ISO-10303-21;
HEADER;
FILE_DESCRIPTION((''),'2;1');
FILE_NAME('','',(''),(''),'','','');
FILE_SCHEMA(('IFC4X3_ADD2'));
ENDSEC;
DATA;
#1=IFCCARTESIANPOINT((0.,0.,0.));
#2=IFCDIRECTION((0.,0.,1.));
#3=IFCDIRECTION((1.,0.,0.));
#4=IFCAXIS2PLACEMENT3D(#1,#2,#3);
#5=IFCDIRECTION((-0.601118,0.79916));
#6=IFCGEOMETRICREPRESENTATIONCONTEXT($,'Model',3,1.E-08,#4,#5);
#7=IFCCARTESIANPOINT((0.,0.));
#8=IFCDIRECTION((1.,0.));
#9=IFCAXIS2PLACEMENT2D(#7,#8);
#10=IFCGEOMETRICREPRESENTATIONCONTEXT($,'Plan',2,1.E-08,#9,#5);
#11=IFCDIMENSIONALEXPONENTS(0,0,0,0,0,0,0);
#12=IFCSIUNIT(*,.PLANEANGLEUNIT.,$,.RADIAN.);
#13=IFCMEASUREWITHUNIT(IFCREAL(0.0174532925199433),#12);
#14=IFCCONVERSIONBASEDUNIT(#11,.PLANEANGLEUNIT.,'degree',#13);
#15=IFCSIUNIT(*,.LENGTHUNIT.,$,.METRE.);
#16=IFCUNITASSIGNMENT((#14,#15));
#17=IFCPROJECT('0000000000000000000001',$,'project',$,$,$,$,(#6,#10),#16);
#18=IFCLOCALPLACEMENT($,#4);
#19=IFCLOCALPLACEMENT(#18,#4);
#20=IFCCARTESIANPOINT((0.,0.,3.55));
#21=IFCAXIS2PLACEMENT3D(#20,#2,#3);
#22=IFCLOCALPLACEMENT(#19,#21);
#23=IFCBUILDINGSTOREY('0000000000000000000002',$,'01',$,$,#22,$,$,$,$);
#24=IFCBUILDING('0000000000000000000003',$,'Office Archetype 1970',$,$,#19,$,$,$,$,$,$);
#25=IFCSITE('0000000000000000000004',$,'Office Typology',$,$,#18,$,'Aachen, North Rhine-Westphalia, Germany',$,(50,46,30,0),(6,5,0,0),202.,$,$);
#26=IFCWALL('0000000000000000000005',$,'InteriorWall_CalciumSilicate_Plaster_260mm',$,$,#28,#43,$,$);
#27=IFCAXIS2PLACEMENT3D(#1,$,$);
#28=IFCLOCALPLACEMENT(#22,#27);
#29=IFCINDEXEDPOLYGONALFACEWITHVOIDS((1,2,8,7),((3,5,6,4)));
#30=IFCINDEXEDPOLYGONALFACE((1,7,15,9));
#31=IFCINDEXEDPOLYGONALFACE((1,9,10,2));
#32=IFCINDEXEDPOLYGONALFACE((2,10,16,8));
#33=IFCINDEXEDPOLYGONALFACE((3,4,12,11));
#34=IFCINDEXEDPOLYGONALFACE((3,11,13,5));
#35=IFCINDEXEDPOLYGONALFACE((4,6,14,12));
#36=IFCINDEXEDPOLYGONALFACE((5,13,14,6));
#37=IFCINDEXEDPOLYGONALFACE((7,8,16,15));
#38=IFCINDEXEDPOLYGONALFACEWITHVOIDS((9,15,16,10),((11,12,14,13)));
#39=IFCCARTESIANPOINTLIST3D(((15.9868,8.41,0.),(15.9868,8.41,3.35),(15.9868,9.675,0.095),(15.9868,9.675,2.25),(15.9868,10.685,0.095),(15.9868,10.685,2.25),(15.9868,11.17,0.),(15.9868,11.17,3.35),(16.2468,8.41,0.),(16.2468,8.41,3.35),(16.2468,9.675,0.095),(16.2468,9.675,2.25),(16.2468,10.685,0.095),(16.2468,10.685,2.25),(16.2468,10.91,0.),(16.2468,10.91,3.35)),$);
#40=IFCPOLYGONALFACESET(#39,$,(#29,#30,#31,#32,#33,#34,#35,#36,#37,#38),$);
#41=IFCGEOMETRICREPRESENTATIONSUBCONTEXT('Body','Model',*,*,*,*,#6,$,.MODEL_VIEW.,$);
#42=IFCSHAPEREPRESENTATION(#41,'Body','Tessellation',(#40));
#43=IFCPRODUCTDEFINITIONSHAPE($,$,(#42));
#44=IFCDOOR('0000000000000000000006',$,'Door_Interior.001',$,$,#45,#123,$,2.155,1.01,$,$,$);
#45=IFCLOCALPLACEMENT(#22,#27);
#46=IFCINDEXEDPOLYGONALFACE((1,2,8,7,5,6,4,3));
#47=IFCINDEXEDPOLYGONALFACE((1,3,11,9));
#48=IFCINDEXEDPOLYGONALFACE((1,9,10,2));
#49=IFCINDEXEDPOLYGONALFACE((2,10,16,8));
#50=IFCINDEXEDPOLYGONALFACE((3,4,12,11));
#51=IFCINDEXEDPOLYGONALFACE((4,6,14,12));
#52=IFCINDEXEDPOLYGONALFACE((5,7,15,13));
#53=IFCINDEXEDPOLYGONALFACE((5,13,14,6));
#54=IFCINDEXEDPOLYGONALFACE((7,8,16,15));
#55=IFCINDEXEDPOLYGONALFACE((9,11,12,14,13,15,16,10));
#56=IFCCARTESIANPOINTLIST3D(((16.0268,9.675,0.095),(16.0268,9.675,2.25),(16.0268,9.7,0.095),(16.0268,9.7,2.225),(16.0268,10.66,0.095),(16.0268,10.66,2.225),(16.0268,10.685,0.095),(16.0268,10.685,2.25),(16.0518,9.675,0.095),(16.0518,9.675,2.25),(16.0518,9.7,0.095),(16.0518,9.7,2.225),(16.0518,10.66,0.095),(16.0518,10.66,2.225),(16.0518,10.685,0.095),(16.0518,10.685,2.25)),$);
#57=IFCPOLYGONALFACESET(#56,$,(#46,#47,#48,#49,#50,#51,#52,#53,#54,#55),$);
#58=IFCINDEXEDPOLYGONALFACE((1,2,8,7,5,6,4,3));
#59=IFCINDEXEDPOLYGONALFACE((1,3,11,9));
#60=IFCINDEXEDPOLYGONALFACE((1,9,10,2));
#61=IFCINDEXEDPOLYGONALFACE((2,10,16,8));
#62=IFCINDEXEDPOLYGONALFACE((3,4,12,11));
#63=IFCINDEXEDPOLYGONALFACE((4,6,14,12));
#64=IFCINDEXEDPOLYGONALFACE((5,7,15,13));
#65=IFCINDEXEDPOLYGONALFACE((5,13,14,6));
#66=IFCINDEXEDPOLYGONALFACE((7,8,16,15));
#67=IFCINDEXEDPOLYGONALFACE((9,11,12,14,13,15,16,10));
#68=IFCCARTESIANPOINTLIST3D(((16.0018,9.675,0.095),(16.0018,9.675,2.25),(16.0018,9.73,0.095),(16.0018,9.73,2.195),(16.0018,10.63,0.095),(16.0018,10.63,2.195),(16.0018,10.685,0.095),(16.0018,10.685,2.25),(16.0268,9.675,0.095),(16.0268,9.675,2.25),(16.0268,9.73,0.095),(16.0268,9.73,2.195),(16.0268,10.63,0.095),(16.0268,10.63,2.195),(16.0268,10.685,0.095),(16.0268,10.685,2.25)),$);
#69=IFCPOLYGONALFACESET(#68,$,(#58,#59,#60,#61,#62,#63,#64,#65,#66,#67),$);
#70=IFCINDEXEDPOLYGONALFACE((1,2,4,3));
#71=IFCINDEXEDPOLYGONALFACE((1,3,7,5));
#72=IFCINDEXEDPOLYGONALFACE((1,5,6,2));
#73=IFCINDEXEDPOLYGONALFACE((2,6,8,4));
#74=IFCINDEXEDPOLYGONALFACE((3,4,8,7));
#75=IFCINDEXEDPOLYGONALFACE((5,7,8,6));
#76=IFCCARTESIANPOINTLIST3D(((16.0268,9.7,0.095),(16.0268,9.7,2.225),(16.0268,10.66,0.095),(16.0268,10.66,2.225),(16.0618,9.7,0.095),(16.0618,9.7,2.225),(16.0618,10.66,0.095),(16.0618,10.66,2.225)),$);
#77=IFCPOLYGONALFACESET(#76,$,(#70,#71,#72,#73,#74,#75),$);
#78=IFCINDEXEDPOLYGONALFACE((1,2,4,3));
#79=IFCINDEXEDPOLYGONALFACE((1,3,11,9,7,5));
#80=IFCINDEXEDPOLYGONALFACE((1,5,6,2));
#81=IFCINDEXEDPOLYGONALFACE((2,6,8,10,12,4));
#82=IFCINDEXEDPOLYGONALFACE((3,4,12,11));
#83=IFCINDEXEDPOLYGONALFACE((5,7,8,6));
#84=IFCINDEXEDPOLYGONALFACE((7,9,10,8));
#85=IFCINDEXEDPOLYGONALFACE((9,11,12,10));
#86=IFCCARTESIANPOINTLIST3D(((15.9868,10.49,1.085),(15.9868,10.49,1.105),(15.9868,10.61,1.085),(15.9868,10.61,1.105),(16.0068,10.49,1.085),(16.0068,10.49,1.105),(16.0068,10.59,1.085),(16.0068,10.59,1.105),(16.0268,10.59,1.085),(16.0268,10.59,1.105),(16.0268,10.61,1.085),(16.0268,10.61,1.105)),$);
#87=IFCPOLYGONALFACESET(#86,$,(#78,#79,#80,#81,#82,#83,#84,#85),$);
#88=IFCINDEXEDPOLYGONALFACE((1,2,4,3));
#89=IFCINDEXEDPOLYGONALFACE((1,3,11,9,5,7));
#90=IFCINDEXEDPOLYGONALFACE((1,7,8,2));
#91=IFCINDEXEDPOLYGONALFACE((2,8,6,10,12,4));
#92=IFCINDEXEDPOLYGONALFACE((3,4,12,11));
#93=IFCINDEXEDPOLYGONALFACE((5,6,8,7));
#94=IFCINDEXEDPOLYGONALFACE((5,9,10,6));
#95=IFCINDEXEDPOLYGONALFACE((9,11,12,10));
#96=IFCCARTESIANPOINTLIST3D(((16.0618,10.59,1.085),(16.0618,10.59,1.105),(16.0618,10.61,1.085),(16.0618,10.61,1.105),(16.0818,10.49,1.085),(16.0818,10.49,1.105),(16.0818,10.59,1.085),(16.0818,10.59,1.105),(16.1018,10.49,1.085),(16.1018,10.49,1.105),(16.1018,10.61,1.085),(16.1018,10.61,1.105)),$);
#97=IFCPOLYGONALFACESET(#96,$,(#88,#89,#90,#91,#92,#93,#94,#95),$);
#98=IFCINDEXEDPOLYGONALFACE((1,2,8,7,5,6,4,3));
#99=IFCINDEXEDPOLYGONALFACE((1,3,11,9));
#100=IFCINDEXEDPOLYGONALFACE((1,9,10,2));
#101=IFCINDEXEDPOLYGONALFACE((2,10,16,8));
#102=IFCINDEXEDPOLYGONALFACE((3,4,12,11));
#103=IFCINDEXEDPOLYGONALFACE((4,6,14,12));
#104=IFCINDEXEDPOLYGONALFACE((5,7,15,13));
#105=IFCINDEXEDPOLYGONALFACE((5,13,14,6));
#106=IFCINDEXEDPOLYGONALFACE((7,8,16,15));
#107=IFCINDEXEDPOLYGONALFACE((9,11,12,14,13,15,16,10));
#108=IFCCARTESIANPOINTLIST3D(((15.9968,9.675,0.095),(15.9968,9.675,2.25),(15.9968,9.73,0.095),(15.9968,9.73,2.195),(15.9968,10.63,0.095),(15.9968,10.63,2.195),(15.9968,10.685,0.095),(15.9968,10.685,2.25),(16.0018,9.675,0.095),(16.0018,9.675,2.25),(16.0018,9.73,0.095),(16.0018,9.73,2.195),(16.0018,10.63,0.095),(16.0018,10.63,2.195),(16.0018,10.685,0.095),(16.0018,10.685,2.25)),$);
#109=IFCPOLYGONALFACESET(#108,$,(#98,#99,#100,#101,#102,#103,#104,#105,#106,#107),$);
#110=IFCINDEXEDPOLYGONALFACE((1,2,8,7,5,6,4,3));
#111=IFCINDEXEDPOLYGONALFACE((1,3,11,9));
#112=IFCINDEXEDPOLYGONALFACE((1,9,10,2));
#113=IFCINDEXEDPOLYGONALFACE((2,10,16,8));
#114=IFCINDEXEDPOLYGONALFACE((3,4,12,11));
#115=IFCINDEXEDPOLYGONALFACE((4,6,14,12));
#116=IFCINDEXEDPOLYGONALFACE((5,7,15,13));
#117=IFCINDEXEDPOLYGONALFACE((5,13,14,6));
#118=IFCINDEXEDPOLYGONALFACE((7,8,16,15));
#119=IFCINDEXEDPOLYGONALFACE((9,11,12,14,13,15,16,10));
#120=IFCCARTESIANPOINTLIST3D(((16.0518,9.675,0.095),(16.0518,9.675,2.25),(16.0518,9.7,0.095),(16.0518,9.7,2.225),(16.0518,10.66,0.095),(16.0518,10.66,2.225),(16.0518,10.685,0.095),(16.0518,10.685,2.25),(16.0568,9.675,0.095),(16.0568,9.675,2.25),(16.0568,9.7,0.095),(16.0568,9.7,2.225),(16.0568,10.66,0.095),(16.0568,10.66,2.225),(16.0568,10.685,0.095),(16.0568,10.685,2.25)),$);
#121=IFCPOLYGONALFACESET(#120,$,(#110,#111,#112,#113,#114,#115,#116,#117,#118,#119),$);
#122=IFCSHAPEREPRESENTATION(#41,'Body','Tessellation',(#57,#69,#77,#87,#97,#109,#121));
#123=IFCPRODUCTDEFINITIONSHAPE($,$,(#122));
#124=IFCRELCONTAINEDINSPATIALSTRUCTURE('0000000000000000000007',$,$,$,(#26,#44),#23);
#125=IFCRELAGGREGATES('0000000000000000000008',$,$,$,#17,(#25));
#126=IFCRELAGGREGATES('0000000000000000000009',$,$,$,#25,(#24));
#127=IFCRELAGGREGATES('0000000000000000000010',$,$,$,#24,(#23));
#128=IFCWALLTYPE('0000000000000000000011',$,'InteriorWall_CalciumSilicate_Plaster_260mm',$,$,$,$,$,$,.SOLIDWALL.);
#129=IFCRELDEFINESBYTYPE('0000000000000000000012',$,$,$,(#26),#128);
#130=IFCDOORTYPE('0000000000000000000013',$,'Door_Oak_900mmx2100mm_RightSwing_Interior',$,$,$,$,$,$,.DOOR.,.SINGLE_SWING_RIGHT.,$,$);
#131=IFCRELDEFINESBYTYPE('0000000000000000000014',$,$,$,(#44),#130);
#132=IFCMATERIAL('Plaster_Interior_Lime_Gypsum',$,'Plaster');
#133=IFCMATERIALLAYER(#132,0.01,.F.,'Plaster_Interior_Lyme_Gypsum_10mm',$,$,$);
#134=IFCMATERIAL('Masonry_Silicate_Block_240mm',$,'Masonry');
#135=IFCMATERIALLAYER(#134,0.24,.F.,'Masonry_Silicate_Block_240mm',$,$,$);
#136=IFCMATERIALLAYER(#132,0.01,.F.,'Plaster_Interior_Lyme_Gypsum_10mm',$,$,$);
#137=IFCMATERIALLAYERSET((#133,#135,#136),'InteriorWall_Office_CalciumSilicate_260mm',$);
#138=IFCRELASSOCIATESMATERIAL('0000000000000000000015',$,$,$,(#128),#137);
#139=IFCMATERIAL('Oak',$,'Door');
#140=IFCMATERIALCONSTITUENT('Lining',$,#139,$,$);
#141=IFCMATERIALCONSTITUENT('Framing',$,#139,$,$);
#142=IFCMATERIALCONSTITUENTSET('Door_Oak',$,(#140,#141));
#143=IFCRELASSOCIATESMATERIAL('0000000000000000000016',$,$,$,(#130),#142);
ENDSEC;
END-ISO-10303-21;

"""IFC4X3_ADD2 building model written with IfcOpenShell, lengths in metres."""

from ifc_helpers import new_model, entity, si_unit, converted_unit, direction, frame, origin_with_axes, origin_2d_with_axis, place, context, subcontext, project, spatial, line, indexed_curve, outline, extrude, source, transform, mapped, material, layer, layer_set, constituent, constituent_set, type_object, type_shapes, element, fill, save


model = new_model("IFC4X3_ADD2")

# Units and contexts
model_context = context("Model", 3, precision=1e-08, world=origin_with_axes(), true_north=direction((-0.601118, 0.79916)))
plan_context = context("Plan", 2, precision=1e-08, world=origin_2d_with_axis(), true_north=direction((-0.601118, 0.79916)))
body_context = subcontext(model_context, "Body", "Model", "MODEL_VIEW")
ifc_project = project(units=[converted_unit("PLANEANGLEUNIT", "degree", entity("IfcReal", 0.0174532925199433), si_unit("PLANEANGLEUNIT", "RADIAN"), dimensions=[0, 0, 0, 0, 0, 0, 0]), si_unit("LENGTHUNIT", "METRE")], contexts=[model_context, plan_context])

# Site, building, storey
site_placement = place(None, origin_with_axes())
site = spatial("IfcSite", under=ifc_project, at=site_placement, Name="Office Typology", LongName="Aachen, North Rhine-Westphalia, Germany", RefLatitude=(50, 46, 30, 0), RefLongitude=(6, 5, 0, 0), RefElevation=202.0)
building_placement = place(site_placement, origin_with_axes())
building = spatial("IfcBuilding", under=site, at=building_placement, Name="Office Archetype 1970")
storey_placement = place(building_placement, frame((0.0, 0.0, 3.55), z_axis=(0.0, 0.0, 1.0), x_axis=(1.0, 0.0, 0.0)))
storey = spatial("IfcBuildingStorey", under=building, at=storey_placement, Name="01")

# Wall, opening, door
ifc_material_1 = material(Name="Plaster_Interior_Lime_Gypsum", Category="Plaster")
ifc_layer_1 = layer(ifc_material_1, 0.01, ventilated=False, Name="Plaster_Interior_Lyme_Gypsum_10mm")
ifc_material_2 = material(Name="Masonry_Silicate_Block_240mm", Category="Masonry")
ifc_layer_2 = layer(ifc_material_2, 0.24, ventilated=False, Name="Masonry_Silicate_Block_240mm")
ifc_layer_3 = layer(ifc_material_1, 0.01, ventilated=False, Name="Plaster_Interior_Lyme_Gypsum_10mm")
ifc_layer_set_1 = layer_set([ifc_layer_1, ifc_layer_2, ifc_layer_3], Name="InteriorWall_Office_CalciumSilicate_260mm")
wall_type_1 = type_object("IfcWallType", Name="InteriorWall_CalciumSilicate_Plaster_260mm", PredefinedType="SOLIDWALL", material=ifc_layer_set_1)
wall_1_placement = place(storey_placement, frame((15.9868, 11.17, 0.0), z_axis=(0.0, 0.0, 1.0), x_axis=(0.0, -1.0, 0.0)))
wall_1 = element("IfcWall", 1, at=wall_1_placement, inside=storey, type_object=wall_type_1, Name="InteriorWall_CalciumSilicate_Plaster_260mm", context=body_context, shape_type="SweptSolid", body=[
    extrude(outline(indexed_curve([(0.0, 0.0), (0.26, 0.26), (2.76, 0.26), (2.76, 0.0)], segments=[line(1, 2, 3, 4, 1)])), origin_with_axes(), (0.0, 0.0, 1.0), 3.35),
])
shared_shape_1 = source(origin_with_axes(), body_context, "Body", "SweptSolid", [
    extrude(outline(indexed_curve([(0.0, 0.0), (1.01, 0.0), (1.01, 2.155), (0.0, 2.155), (0.0, 0.0)])), frame((0.0, -0.015, 0.0), z_axis=(0.0, -1.0, 0.0), x_axis=(1.0, 0.0, 0.0)), (0.0, 0.0, -1.0), 0.26),
])
opening_1_placement = place(wall_1_placement, frame((0.485, 0.015, 0.095), z_axis=(0.0, 0.0, 1.0), x_axis=(1.0, 0.0, 0.0)))
opening_1 = element("IfcOpeningElement", 2, at=opening_1_placement, cuts=wall_1, PredefinedType="OPENING", context=body_context, shape_type="MappedRepresentation", body=[
    mapped(shared_shape_1, transform((0.0, 0.0, 0.0), x_axis=(1.0, 0.0, 0.0), y_axis=(0.0, 1.0, 0.0), z_axis=(0.0, 0.0, 1.0), scale=1.0)),
])
ifc_material_3 = material(Name="Oak", Category="Door")
ifc_constituent_1 = constituent(ifc_material_3, Name="Lining")
ifc_constituent_2 = constituent(ifc_material_3, Name="Framing")
ifc_constituent_set_1 = constituent_set(constituents=[ifc_constituent_1, ifc_constituent_2], Name="Door_Oak")
door_type = type_object("IfcDoorType", Name="Door_Oak_900mmx2100mm_RightSwing_Interior", OperationType="SINGLE_SWING_RIGHT", PredefinedType="DOOR", material=ifc_constituent_set_1)
shared_shape_2 = source(origin_with_axes(), body_context, "Body", "SweptSolid", [
    extrude(outline(indexed_curve([(0.0, 0.0), (0.0, 2.155), (1.01, 2.155), (1.01, 0.0), (0.985, 0.0), (0.985, 2.13), (0.025, 2.13), (0.025, 0.0)], segments=[line(1, 2, 3, 4, 5, 6, 7, 8, 1)])), frame((0.0, 0.025, 0.0), z_axis=(0.0, -1.0, 0.0), x_axis=(1.0, 0.0, 0.0)), (0.0, 0.0, -1.0), 0.025),
    extrude(outline(indexed_curve([(0.0, 0.0), (0.0, 2.155), (1.01, 2.155), (1.01, 0.0), (0.955, 0.0), (0.955, 2.1), (0.055, 2.1), (0.055, 0.0)], segments=[line(1, 2, 3, 4, 5, 6, 7, 8, 1)])), frame((0.0, 0.0, 0.0), z_axis=(0.0, -1.0, 0.0), x_axis=(1.0, 0.0, 0.0)), (0.0, 0.0, -1.0), 0.025),
    extrude(outline(indexed_curve([(0.0, 0.0), (0.96, 0.0), (0.96, 0.035), (0.0, 0.035)], segments=[line(1, 2, 3, 4, 1)])), frame((0.025, 0.025, 0.0), z_axis=(0.0, 0.0, 1.0), x_axis=(1.0, 0.0, 0.0)), (0.0, 0.0, 1.0), 2.13),
    extrude(outline(indexed_curve([(0.0, 0.0), (0.0, -0.04), (0.12, -0.04), (0.12, -0.02), (0.02, -0.02), (0.02, 0.0)], segments=[line(1, 2, 3, 4, 5, 6, 1)])), frame((0.075, 0.025, 0.99), z_axis=(0.0, 0.0, 1.0), x_axis=(1.0, 0.0, 0.0)), (0.0, 0.0, 1.0), 0.02),
    extrude(outline(indexed_curve([(0.0, 0.0), (0.0, 0.04), (0.12, 0.04), (0.12, 0.02), (0.02, 0.02), (0.02, 0.0)], segments=[line(1, 2, 3, 4, 5, 6, 1)])), frame((0.075, 0.06, 0.99), z_axis=(0.0, 0.0, 1.0), x_axis=(1.0, 0.0, 0.0)), (0.0, 0.0, 1.0), 0.02),
    extrude(outline(indexed_curve([(0.0, 0.0), (0.0, 2.155), (1.01, 2.155), (1.01, 0.0), (0.955, 0.0), (0.955, 2.1), (0.055, 2.1), (0.055, 0.0)], segments=[line(1, 2, 3, 4, 5, 6, 7, 8, 1)])), frame((0.0, -0.005, 0.0), z_axis=(0.0, -1.0, 0.0), x_axis=(1.0, 0.0, 0.0)), (0.0, 0.0, -1.0), 0.005),
    extrude(outline(indexed_curve([(0.0, 0.0), (0.0, 2.155), (1.01, 2.155), (1.01, 0.0), (0.985, 0.0), (0.985, 2.13), (0.025, 2.13), (0.025, 0.0)], segments=[line(1, 2, 3, 4, 5, 6, 7, 8, 1)])), frame((0.0, 0.05, 0.0), z_axis=(0.0, -1.0, 0.0), x_axis=(1.0, 0.0, 0.0)), (0.0, 0.0, -1.0), 0.005),
])
type_shapes(door_type, [shared_shape_2])
door_placement = place(opening_1_placement, origin_with_axes())
door = element("IfcDoor", 3, at=door_placement, inside=storey, type_object=door_type, Name="Door_Interior.001", OverallHeight=2.155, OverallWidth=1.01, context=body_context, shape_type="MappedRepresentation", body=[
    mapped(shared_shape_2, transform((0.0, 0.0, 0.0), x_axis=(1.0, 0.0, 0.0), y_axis=(0.0, 1.0, 0.0), z_axis=(0.0, 0.0, 1.0), scale=1.0)),
])
fill(opening_1, door)

save(model, "model.ifc")
